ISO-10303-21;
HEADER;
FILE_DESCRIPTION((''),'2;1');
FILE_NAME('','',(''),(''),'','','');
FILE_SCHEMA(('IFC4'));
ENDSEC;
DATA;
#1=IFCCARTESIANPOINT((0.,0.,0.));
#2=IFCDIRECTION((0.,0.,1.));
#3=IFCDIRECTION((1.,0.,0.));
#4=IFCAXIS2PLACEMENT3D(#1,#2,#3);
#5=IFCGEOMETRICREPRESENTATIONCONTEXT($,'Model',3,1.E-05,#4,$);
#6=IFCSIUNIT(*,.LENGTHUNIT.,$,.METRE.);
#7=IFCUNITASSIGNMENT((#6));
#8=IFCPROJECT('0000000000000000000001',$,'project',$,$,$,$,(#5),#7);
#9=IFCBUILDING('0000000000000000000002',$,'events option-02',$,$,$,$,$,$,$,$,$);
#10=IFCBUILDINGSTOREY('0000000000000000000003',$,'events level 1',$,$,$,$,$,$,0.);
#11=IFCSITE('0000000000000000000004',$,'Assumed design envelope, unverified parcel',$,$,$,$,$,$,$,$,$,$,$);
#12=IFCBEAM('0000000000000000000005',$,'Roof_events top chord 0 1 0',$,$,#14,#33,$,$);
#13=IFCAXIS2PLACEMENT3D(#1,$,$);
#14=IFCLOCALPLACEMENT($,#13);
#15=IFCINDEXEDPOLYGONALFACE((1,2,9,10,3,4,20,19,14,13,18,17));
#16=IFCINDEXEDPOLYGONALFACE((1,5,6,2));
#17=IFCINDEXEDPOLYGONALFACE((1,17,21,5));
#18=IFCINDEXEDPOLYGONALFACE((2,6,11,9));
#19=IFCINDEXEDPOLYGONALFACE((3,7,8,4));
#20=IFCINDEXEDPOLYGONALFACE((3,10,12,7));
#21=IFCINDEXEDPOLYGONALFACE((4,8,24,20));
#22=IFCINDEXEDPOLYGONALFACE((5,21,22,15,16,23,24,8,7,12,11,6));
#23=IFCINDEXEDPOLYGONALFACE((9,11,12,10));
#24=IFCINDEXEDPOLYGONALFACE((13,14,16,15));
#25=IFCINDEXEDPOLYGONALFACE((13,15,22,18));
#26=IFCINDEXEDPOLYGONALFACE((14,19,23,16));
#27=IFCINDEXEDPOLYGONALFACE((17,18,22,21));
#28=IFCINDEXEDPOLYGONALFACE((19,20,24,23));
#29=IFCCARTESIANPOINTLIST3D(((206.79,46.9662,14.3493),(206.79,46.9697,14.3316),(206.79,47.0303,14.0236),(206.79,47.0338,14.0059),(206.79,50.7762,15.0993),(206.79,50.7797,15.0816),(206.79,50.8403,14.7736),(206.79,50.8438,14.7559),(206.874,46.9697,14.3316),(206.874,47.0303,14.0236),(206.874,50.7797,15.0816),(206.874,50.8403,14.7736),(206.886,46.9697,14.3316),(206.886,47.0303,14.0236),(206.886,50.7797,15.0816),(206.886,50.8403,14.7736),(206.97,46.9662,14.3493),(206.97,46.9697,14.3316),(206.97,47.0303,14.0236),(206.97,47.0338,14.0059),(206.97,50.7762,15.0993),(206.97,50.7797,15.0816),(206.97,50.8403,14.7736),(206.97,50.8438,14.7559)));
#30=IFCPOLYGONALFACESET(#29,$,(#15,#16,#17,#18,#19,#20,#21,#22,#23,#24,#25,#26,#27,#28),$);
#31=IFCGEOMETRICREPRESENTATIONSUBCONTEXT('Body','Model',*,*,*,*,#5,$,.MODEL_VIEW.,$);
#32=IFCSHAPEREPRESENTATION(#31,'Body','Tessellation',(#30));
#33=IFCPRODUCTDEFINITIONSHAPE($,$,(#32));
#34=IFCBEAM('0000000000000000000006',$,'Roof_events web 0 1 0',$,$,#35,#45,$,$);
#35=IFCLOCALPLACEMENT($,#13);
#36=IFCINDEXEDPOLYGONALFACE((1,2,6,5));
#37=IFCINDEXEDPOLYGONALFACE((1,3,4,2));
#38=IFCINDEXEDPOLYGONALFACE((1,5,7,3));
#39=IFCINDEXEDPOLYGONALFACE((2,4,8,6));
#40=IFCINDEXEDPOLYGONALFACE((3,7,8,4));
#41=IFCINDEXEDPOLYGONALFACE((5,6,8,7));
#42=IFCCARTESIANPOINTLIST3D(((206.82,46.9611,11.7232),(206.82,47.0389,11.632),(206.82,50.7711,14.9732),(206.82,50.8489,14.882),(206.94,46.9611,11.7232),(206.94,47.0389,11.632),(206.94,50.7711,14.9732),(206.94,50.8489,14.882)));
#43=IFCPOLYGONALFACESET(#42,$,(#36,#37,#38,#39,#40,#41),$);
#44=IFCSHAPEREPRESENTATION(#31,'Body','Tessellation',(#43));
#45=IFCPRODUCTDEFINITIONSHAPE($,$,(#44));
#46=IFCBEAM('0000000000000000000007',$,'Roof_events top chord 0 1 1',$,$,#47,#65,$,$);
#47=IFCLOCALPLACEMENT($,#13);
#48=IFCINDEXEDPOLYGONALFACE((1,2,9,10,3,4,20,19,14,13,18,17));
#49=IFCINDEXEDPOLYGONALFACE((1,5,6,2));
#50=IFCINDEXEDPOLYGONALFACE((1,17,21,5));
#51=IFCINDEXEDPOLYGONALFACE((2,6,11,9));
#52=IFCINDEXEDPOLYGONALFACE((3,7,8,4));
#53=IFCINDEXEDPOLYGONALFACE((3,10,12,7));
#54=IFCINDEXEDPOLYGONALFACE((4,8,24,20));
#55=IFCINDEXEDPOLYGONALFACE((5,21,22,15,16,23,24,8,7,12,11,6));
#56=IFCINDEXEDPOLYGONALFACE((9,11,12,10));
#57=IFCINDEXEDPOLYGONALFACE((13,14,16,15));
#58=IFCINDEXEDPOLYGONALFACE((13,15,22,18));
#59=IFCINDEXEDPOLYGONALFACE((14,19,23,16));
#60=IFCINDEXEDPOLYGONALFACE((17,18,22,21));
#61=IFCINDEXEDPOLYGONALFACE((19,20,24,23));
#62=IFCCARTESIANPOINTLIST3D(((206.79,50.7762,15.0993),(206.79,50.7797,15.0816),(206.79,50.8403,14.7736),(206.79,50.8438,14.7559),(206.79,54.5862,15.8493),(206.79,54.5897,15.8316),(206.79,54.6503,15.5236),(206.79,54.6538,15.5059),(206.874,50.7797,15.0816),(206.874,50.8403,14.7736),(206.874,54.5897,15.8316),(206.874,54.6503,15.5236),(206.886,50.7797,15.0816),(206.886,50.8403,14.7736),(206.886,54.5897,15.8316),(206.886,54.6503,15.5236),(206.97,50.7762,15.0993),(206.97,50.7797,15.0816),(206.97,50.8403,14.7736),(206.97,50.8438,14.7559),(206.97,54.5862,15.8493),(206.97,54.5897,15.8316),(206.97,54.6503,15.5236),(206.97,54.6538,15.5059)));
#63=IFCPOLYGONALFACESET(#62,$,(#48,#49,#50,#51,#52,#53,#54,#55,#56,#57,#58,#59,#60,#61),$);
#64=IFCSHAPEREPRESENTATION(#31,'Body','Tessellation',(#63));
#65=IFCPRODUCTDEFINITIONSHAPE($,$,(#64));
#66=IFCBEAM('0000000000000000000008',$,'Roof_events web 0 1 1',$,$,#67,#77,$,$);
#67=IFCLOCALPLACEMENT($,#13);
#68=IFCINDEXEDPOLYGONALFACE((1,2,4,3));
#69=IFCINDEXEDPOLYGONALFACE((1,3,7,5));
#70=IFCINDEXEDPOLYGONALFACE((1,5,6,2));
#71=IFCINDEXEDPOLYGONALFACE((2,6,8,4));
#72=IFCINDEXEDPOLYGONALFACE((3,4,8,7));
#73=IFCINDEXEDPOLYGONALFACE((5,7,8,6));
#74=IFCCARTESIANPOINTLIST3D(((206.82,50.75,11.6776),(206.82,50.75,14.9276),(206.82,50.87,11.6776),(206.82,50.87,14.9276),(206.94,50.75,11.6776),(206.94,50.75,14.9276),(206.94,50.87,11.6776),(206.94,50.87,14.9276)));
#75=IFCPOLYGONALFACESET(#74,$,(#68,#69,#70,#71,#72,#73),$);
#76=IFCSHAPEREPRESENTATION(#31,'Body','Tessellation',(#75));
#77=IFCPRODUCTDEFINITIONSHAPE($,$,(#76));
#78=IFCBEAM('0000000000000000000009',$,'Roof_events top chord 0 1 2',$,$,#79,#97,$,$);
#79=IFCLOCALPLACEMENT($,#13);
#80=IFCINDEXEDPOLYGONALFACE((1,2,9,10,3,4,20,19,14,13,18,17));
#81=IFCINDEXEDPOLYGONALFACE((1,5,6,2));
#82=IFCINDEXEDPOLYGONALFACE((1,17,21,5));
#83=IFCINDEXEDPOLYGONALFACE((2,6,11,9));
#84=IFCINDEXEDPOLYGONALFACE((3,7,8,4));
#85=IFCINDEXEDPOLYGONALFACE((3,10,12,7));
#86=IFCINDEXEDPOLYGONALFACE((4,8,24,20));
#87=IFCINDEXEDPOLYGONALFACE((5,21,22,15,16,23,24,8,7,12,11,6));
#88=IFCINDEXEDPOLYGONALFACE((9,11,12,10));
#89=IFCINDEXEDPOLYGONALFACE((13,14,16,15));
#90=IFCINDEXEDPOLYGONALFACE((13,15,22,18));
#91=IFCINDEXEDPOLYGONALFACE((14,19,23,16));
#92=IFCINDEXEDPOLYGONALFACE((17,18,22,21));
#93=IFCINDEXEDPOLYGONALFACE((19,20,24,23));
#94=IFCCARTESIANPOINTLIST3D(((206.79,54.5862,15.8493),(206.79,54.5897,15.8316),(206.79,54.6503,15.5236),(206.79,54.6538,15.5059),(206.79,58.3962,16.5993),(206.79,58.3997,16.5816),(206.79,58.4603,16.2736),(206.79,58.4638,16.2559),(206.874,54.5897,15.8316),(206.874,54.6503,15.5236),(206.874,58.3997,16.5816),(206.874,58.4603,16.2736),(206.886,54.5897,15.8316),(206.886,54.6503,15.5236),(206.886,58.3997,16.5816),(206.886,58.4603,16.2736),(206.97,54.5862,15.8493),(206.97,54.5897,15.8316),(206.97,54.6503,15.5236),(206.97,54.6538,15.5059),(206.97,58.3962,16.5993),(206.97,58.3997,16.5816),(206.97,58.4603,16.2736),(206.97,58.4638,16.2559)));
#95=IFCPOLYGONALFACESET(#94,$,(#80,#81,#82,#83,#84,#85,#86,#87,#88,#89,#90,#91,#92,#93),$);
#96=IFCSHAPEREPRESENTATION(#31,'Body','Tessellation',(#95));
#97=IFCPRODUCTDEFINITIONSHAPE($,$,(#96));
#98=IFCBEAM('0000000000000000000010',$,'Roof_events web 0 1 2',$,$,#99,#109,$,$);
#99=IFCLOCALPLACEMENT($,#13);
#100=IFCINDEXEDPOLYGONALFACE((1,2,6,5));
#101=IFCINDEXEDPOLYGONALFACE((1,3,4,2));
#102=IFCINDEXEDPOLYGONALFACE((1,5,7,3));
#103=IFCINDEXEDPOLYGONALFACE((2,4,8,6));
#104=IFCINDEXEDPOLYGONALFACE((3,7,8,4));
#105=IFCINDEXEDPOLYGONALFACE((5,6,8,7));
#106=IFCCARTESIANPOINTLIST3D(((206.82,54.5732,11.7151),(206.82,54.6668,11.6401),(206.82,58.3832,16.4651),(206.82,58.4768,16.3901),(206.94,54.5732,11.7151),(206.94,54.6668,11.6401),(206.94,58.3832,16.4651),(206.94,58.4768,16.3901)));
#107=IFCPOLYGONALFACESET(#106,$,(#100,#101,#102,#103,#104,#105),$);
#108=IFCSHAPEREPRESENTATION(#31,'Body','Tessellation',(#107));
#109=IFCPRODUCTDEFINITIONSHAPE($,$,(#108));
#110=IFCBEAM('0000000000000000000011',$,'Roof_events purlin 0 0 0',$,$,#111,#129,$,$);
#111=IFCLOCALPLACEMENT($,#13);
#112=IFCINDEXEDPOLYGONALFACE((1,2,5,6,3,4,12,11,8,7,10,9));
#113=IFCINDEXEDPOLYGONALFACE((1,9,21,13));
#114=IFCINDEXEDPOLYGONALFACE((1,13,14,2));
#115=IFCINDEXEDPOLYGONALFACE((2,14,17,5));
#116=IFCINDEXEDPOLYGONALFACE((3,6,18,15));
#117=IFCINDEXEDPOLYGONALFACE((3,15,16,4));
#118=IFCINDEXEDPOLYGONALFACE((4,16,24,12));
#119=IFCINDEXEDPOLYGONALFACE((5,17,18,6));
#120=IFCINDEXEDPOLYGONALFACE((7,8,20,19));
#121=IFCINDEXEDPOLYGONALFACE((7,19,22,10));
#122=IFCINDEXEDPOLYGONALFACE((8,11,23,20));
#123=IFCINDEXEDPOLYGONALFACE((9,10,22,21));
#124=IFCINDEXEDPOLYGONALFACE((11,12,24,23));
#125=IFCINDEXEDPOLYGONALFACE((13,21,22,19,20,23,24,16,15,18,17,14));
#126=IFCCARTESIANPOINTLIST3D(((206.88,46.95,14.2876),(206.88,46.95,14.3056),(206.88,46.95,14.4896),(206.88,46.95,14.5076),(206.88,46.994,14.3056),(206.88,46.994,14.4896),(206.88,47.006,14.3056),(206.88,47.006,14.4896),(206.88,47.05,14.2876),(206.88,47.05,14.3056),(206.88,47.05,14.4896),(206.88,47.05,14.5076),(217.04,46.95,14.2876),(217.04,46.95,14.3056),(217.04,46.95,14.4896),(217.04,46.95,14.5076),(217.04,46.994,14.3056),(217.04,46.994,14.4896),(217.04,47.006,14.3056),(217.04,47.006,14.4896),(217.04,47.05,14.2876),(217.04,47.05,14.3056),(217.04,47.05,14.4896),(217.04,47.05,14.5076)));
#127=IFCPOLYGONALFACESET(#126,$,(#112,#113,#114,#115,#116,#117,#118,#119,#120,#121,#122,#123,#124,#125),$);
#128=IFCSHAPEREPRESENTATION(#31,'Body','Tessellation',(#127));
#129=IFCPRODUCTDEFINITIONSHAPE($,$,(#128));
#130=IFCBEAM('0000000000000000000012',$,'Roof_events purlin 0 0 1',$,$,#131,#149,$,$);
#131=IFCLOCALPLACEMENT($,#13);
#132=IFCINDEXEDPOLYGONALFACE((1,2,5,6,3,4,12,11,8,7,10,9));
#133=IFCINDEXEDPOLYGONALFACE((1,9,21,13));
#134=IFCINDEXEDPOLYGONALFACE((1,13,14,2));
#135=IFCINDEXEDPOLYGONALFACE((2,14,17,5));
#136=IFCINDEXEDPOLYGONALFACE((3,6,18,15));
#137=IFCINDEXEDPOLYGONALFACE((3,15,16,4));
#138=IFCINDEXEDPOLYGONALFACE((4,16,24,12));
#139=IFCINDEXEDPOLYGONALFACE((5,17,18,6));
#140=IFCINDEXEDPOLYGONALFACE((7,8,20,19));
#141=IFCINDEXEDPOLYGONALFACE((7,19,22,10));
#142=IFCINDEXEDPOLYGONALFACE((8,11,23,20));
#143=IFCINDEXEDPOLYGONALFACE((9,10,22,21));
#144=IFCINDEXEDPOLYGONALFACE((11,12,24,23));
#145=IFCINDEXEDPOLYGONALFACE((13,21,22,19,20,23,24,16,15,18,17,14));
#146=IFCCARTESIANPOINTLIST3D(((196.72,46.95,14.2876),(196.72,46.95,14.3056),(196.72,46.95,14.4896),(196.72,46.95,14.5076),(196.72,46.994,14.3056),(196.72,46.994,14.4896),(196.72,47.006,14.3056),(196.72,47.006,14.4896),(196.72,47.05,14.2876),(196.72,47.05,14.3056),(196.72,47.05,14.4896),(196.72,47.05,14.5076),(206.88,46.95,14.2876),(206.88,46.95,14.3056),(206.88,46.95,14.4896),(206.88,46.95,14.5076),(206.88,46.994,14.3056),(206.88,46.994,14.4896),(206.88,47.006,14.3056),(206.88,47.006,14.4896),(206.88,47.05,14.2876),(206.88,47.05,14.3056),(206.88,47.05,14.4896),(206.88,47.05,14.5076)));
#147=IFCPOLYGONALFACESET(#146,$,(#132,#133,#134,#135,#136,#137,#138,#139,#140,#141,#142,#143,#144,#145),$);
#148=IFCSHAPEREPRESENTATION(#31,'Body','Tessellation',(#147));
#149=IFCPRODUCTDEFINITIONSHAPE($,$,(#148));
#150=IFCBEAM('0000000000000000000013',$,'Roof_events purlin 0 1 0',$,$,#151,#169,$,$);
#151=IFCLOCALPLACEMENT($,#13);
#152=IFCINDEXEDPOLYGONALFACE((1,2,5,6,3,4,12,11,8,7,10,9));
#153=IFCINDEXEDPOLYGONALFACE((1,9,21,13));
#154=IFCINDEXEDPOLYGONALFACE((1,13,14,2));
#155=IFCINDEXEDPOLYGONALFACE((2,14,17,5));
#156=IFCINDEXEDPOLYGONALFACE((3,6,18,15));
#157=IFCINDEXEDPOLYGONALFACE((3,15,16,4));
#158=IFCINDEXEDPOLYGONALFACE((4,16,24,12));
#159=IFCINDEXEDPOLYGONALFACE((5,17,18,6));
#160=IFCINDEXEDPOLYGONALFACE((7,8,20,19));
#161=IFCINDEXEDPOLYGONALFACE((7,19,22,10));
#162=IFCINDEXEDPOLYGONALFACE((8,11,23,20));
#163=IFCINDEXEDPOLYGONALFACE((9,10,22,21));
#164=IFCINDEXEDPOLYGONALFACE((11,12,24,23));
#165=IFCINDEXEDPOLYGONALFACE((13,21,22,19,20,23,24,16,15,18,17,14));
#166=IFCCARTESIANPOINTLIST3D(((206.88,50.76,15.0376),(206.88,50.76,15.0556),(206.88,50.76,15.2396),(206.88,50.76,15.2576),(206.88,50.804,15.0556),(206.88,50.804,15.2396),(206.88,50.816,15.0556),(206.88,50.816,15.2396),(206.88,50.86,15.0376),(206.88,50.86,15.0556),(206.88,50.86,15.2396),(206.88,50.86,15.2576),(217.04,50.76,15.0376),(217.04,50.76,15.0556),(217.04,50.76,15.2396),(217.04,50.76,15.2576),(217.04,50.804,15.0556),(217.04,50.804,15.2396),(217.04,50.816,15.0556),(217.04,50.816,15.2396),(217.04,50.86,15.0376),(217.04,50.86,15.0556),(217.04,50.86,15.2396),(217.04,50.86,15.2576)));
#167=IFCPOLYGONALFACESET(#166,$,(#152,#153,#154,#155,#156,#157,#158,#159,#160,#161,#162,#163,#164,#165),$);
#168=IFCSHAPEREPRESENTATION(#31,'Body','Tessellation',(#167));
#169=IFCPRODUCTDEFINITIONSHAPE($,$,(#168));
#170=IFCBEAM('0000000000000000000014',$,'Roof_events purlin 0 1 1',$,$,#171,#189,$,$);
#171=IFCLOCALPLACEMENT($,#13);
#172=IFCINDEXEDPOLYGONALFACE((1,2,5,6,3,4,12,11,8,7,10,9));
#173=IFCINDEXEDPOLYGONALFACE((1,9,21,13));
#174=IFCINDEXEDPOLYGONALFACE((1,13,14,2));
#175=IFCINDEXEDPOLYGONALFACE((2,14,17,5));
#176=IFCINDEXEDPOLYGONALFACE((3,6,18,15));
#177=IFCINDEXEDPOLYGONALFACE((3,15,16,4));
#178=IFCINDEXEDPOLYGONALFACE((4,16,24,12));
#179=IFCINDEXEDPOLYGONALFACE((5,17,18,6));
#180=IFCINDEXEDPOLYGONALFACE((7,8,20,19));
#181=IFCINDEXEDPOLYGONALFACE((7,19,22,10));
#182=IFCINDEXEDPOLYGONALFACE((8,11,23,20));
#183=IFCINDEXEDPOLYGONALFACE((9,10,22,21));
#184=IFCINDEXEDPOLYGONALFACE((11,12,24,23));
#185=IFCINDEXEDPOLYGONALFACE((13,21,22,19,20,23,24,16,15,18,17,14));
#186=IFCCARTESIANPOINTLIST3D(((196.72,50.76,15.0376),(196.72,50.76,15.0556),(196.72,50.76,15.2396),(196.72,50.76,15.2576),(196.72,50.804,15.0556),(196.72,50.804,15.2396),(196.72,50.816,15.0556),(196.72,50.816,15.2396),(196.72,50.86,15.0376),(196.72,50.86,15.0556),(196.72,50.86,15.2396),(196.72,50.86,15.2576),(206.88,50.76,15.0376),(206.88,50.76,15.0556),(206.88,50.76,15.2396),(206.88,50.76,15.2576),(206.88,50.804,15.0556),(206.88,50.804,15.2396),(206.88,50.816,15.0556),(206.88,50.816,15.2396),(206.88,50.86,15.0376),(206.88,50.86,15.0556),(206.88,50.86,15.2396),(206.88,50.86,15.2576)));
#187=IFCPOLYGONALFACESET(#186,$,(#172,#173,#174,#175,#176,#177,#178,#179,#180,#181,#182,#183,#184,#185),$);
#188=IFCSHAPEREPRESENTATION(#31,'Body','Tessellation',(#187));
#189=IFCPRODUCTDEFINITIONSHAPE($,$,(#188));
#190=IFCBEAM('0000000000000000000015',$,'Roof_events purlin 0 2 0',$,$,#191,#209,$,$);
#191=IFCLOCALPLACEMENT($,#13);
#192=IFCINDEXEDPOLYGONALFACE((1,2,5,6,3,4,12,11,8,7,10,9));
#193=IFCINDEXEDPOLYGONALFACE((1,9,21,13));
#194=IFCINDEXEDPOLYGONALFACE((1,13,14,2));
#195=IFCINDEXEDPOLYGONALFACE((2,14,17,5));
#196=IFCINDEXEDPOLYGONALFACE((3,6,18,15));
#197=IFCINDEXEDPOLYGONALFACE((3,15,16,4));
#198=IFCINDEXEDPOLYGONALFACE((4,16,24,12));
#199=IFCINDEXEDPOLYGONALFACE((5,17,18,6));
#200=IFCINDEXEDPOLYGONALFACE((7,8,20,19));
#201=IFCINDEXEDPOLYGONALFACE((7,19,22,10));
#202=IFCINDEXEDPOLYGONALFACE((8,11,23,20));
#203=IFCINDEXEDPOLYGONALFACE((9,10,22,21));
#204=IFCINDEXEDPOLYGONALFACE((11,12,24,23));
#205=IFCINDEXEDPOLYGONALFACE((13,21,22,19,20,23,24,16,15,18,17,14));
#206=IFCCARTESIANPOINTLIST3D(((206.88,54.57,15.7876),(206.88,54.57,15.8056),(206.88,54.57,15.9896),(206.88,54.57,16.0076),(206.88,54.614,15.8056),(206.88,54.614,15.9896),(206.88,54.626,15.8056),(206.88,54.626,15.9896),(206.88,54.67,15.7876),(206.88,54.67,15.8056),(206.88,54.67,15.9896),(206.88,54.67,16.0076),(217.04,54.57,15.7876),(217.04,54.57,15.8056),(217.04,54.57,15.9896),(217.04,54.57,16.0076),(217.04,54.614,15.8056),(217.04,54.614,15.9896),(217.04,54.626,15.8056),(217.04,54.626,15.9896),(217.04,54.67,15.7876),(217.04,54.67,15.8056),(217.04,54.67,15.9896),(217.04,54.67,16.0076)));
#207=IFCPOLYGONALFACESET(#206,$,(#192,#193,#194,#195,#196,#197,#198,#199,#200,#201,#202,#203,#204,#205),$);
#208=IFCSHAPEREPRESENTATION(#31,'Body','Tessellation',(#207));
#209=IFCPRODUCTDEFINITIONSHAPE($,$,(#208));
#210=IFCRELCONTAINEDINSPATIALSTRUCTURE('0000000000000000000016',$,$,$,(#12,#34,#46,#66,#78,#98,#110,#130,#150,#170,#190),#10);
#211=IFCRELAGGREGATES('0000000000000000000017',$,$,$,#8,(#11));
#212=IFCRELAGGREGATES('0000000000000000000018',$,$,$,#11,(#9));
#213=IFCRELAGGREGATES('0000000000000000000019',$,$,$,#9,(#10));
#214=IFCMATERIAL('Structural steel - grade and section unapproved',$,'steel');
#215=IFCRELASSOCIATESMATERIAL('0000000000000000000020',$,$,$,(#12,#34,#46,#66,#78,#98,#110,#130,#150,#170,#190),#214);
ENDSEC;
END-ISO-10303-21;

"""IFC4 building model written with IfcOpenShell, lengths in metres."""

from ifc_helpers import new_model, si_unit, frame, origin_with_axes, place, context, subcontext, project, spatial, rectangle, i_section, extrude, material, element, save


model = new_model("IFC4")

# Units and contexts
model_context = context("Model", 3, precision=1e-05, world=origin_with_axes())
body_context = subcontext(model_context, "Body", "Model", "MODEL_VIEW")
ifc_project = project(units=[si_unit("LENGTHUNIT", "METRE")], contexts=[model_context])

# Site, building, storey
site = spatial("IfcSite", under=ifc_project, Name="Assumed design envelope, unverified parcel")
building = spatial("IfcBuilding", under=site, Name="events option-02")
storey = spatial("IfcBuildingStorey", under=building, Name="events level 1", Elevation=0.0)

# Shared definitions
ifc_material_1 = material(Name="Structural steel - grade and section unapproved", Category="steel")

# Beams
beam_1_placement = place(None, frame((206.88, 47.0, 14.1776), z_axis=(0.0, 0.98117, 0.193144), x_axis=(-1.0, 0.0, 0.0)))
element("IfcBeam", 1, at=beam_1_placement, inside=storey, material=ifc_material_1, Name="Roof_events top chord 0 1 0", context=body_context, shape_type="SweptSolid", body=[
    extrude(i_section(OverallWidth=0.18, OverallDepth=0.35, WebThickness=0.012, FlangeThickness=0.018, FilletRadius=0.0), origin_with_axes(), (0.0, 0.0, 1.0), 3.8831),
])
beam_2_placement = place(None, frame((206.88, 47.0, 11.6776), z_axis=(0.0, 0.760805, 0.64898), x_axis=(-1.0, 0.0, 0.0)))
element("IfcBeam", 2, at=beam_2_placement, inside=storey, material=ifc_material_1, Name="Roof_events web 0 1 0", context=body_context, shape_type="SweptSolid", body=[
    extrude(rectangle(XDim=0.12, YDim=0.12), origin_with_axes(), (0.0, 0.0, 1.0), 5.0079),
])
beam_3_placement = place(None, frame((206.88, 50.81, 14.9276), z_axis=(0.0, 0.98117, 0.193144), x_axis=(-1.0, 0.0, 0.0)))
element("IfcBeam", 3, at=beam_3_placement, inside=storey, material=ifc_material_1, Name="Roof_events top chord 0 1 1", context=body_context, shape_type="SweptSolid", body=[
    extrude(i_section(OverallWidth=0.18, OverallDepth=0.35, WebThickness=0.012, FlangeThickness=0.018, FilletRadius=0.0), origin_with_axes(), (0.0, 0.0, 1.0), 3.8831),
])
beam_4_placement = place(None, frame((206.88, 50.81, 11.6776), z_axis=(0.0, 0.0, 1.0), x_axis=(-1.0, 0.0, 0.0)))
element("IfcBeam", 4, at=beam_4_placement, inside=storey, material=ifc_material_1, Name="Roof_events web 0 1 1", context=body_context, shape_type="SweptSolid", body=[
    extrude(rectangle(XDim=0.12, YDim=0.12), origin_with_axes(), (0.0, 0.0, 1.0), 3.25),
])
beam_5_placement = place(None, frame((206.88, 54.62, 15.6776), z_axis=(0.0, 0.98117, 0.193144), x_axis=(-1.0, 0.0, 0.0)))
element("IfcBeam", 5, at=beam_5_placement, inside=storey, material=ifc_material_1, Name="Roof_events top chord 0 1 2", context=body_context, shape_type="SweptSolid", body=[
    extrude(i_section(OverallWidth=0.18, OverallDepth=0.35, WebThickness=0.012, FlangeThickness=0.018, FilletRadius=0.0), origin_with_axes(), (0.0, 0.0, 1.0), 3.8831),
])
beam_6_placement = place(None, frame((206.88, 54.62, 11.6776), z_axis=(0.0, 0.625696, 0.780067), x_axis=(-1.0, 0.0, 0.0)))
element("IfcBeam", 6, at=beam_6_placement, inside=storey, material=ifc_material_1, Name="Roof_events web 0 1 2", context=body_context, shape_type="SweptSolid", body=[
    extrude(rectangle(XDim=0.12, YDim=0.12), origin_with_axes(), (0.0, 0.0, 1.0), 6.0892),
])
beam_7_placement = place(None, frame((217.04, 47.0, 14.3976), z_axis=(-1.0, 0.0, 0.0), x_axis=(0.0, -1.0, 0.0)))
element("IfcBeam", 7, at=beam_7_placement, inside=storey, material=ifc_material_1, Name="Roof_events purlin 0 0 0", context=body_context, shape_type="SweptSolid", body=[
    extrude(i_section(OverallWidth=0.1, OverallDepth=0.22, WebThickness=0.012, FlangeThickness=0.018, FilletRadius=0.0), origin_with_axes(), (0.0, 0.0, 1.0), 10.16),
])
beam_8_placement = place(None, frame((206.88, 47.0, 14.3976), z_axis=(-1.0, 0.0, 0.0), x_axis=(0.0, -1.0, 0.0)))
element("IfcBeam", 8, at=beam_8_placement, inside=storey, material=ifc_material_1, Name="Roof_events purlin 0 0 1", context=body_context, shape_type="SweptSolid", body=[
    extrude(i_section(OverallWidth=0.1, OverallDepth=0.22, WebThickness=0.012, FlangeThickness=0.018, FilletRadius=0.0), origin_with_axes(), (0.0, 0.0, 1.0), 10.16),
])
beam_9_placement = place(None, frame((217.04, 50.81, 15.1476), z_axis=(-1.0, 0.0, 0.0), x_axis=(0.0, -1.0, 0.0)))
element("IfcBeam", 9, at=beam_9_placement, inside=storey, material=ifc_material_1, Name="Roof_events purlin 0 1 0", context=body_context, shape_type="SweptSolid", body=[
    extrude(i_section(OverallWidth=0.1, OverallDepth=0.22, WebThickness=0.012, FlangeThickness=0.018, FilletRadius=0.0), origin_with_axes(), (0.0, 0.0, 1.0), 10.16),
])
beam_10_placement = place(None, frame((206.88, 50.81, 15.1476), z_axis=(-1.0, 0.0, 0.0), x_axis=(0.0, -1.0, 0.0)))
element("IfcBeam", 10, at=beam_10_placement, inside=storey, material=ifc_material_1, Name="Roof_events purlin 0 1 1", context=body_context, shape_type="SweptSolid", body=[
    extrude(i_section(OverallWidth=0.1, OverallDepth=0.22, WebThickness=0.012, FlangeThickness=0.018, FilletRadius=0.0), origin_with_axes(), (0.0, 0.0, 1.0), 10.16),
])
beam_11_placement = place(None, frame((217.04, 54.62, 15.8976), z_axis=(-1.0, 0.0, 0.0), x_axis=(0.0, -1.0, 0.0)))
element("IfcBeam", 11, at=beam_11_placement, inside=storey, material=ifc_material_1, Name="Roof_events purlin 0 2 0", context=body_context, shape_type="SweptSolid", body=[
    extrude(i_section(OverallWidth=0.1, OverallDepth=0.22, WebThickness=0.012, FlangeThickness=0.018, FilletRadius=0.0), origin_with_axes(), (0.0, 0.0, 1.0), 10.16),
])

save(model, "model.ifc")
